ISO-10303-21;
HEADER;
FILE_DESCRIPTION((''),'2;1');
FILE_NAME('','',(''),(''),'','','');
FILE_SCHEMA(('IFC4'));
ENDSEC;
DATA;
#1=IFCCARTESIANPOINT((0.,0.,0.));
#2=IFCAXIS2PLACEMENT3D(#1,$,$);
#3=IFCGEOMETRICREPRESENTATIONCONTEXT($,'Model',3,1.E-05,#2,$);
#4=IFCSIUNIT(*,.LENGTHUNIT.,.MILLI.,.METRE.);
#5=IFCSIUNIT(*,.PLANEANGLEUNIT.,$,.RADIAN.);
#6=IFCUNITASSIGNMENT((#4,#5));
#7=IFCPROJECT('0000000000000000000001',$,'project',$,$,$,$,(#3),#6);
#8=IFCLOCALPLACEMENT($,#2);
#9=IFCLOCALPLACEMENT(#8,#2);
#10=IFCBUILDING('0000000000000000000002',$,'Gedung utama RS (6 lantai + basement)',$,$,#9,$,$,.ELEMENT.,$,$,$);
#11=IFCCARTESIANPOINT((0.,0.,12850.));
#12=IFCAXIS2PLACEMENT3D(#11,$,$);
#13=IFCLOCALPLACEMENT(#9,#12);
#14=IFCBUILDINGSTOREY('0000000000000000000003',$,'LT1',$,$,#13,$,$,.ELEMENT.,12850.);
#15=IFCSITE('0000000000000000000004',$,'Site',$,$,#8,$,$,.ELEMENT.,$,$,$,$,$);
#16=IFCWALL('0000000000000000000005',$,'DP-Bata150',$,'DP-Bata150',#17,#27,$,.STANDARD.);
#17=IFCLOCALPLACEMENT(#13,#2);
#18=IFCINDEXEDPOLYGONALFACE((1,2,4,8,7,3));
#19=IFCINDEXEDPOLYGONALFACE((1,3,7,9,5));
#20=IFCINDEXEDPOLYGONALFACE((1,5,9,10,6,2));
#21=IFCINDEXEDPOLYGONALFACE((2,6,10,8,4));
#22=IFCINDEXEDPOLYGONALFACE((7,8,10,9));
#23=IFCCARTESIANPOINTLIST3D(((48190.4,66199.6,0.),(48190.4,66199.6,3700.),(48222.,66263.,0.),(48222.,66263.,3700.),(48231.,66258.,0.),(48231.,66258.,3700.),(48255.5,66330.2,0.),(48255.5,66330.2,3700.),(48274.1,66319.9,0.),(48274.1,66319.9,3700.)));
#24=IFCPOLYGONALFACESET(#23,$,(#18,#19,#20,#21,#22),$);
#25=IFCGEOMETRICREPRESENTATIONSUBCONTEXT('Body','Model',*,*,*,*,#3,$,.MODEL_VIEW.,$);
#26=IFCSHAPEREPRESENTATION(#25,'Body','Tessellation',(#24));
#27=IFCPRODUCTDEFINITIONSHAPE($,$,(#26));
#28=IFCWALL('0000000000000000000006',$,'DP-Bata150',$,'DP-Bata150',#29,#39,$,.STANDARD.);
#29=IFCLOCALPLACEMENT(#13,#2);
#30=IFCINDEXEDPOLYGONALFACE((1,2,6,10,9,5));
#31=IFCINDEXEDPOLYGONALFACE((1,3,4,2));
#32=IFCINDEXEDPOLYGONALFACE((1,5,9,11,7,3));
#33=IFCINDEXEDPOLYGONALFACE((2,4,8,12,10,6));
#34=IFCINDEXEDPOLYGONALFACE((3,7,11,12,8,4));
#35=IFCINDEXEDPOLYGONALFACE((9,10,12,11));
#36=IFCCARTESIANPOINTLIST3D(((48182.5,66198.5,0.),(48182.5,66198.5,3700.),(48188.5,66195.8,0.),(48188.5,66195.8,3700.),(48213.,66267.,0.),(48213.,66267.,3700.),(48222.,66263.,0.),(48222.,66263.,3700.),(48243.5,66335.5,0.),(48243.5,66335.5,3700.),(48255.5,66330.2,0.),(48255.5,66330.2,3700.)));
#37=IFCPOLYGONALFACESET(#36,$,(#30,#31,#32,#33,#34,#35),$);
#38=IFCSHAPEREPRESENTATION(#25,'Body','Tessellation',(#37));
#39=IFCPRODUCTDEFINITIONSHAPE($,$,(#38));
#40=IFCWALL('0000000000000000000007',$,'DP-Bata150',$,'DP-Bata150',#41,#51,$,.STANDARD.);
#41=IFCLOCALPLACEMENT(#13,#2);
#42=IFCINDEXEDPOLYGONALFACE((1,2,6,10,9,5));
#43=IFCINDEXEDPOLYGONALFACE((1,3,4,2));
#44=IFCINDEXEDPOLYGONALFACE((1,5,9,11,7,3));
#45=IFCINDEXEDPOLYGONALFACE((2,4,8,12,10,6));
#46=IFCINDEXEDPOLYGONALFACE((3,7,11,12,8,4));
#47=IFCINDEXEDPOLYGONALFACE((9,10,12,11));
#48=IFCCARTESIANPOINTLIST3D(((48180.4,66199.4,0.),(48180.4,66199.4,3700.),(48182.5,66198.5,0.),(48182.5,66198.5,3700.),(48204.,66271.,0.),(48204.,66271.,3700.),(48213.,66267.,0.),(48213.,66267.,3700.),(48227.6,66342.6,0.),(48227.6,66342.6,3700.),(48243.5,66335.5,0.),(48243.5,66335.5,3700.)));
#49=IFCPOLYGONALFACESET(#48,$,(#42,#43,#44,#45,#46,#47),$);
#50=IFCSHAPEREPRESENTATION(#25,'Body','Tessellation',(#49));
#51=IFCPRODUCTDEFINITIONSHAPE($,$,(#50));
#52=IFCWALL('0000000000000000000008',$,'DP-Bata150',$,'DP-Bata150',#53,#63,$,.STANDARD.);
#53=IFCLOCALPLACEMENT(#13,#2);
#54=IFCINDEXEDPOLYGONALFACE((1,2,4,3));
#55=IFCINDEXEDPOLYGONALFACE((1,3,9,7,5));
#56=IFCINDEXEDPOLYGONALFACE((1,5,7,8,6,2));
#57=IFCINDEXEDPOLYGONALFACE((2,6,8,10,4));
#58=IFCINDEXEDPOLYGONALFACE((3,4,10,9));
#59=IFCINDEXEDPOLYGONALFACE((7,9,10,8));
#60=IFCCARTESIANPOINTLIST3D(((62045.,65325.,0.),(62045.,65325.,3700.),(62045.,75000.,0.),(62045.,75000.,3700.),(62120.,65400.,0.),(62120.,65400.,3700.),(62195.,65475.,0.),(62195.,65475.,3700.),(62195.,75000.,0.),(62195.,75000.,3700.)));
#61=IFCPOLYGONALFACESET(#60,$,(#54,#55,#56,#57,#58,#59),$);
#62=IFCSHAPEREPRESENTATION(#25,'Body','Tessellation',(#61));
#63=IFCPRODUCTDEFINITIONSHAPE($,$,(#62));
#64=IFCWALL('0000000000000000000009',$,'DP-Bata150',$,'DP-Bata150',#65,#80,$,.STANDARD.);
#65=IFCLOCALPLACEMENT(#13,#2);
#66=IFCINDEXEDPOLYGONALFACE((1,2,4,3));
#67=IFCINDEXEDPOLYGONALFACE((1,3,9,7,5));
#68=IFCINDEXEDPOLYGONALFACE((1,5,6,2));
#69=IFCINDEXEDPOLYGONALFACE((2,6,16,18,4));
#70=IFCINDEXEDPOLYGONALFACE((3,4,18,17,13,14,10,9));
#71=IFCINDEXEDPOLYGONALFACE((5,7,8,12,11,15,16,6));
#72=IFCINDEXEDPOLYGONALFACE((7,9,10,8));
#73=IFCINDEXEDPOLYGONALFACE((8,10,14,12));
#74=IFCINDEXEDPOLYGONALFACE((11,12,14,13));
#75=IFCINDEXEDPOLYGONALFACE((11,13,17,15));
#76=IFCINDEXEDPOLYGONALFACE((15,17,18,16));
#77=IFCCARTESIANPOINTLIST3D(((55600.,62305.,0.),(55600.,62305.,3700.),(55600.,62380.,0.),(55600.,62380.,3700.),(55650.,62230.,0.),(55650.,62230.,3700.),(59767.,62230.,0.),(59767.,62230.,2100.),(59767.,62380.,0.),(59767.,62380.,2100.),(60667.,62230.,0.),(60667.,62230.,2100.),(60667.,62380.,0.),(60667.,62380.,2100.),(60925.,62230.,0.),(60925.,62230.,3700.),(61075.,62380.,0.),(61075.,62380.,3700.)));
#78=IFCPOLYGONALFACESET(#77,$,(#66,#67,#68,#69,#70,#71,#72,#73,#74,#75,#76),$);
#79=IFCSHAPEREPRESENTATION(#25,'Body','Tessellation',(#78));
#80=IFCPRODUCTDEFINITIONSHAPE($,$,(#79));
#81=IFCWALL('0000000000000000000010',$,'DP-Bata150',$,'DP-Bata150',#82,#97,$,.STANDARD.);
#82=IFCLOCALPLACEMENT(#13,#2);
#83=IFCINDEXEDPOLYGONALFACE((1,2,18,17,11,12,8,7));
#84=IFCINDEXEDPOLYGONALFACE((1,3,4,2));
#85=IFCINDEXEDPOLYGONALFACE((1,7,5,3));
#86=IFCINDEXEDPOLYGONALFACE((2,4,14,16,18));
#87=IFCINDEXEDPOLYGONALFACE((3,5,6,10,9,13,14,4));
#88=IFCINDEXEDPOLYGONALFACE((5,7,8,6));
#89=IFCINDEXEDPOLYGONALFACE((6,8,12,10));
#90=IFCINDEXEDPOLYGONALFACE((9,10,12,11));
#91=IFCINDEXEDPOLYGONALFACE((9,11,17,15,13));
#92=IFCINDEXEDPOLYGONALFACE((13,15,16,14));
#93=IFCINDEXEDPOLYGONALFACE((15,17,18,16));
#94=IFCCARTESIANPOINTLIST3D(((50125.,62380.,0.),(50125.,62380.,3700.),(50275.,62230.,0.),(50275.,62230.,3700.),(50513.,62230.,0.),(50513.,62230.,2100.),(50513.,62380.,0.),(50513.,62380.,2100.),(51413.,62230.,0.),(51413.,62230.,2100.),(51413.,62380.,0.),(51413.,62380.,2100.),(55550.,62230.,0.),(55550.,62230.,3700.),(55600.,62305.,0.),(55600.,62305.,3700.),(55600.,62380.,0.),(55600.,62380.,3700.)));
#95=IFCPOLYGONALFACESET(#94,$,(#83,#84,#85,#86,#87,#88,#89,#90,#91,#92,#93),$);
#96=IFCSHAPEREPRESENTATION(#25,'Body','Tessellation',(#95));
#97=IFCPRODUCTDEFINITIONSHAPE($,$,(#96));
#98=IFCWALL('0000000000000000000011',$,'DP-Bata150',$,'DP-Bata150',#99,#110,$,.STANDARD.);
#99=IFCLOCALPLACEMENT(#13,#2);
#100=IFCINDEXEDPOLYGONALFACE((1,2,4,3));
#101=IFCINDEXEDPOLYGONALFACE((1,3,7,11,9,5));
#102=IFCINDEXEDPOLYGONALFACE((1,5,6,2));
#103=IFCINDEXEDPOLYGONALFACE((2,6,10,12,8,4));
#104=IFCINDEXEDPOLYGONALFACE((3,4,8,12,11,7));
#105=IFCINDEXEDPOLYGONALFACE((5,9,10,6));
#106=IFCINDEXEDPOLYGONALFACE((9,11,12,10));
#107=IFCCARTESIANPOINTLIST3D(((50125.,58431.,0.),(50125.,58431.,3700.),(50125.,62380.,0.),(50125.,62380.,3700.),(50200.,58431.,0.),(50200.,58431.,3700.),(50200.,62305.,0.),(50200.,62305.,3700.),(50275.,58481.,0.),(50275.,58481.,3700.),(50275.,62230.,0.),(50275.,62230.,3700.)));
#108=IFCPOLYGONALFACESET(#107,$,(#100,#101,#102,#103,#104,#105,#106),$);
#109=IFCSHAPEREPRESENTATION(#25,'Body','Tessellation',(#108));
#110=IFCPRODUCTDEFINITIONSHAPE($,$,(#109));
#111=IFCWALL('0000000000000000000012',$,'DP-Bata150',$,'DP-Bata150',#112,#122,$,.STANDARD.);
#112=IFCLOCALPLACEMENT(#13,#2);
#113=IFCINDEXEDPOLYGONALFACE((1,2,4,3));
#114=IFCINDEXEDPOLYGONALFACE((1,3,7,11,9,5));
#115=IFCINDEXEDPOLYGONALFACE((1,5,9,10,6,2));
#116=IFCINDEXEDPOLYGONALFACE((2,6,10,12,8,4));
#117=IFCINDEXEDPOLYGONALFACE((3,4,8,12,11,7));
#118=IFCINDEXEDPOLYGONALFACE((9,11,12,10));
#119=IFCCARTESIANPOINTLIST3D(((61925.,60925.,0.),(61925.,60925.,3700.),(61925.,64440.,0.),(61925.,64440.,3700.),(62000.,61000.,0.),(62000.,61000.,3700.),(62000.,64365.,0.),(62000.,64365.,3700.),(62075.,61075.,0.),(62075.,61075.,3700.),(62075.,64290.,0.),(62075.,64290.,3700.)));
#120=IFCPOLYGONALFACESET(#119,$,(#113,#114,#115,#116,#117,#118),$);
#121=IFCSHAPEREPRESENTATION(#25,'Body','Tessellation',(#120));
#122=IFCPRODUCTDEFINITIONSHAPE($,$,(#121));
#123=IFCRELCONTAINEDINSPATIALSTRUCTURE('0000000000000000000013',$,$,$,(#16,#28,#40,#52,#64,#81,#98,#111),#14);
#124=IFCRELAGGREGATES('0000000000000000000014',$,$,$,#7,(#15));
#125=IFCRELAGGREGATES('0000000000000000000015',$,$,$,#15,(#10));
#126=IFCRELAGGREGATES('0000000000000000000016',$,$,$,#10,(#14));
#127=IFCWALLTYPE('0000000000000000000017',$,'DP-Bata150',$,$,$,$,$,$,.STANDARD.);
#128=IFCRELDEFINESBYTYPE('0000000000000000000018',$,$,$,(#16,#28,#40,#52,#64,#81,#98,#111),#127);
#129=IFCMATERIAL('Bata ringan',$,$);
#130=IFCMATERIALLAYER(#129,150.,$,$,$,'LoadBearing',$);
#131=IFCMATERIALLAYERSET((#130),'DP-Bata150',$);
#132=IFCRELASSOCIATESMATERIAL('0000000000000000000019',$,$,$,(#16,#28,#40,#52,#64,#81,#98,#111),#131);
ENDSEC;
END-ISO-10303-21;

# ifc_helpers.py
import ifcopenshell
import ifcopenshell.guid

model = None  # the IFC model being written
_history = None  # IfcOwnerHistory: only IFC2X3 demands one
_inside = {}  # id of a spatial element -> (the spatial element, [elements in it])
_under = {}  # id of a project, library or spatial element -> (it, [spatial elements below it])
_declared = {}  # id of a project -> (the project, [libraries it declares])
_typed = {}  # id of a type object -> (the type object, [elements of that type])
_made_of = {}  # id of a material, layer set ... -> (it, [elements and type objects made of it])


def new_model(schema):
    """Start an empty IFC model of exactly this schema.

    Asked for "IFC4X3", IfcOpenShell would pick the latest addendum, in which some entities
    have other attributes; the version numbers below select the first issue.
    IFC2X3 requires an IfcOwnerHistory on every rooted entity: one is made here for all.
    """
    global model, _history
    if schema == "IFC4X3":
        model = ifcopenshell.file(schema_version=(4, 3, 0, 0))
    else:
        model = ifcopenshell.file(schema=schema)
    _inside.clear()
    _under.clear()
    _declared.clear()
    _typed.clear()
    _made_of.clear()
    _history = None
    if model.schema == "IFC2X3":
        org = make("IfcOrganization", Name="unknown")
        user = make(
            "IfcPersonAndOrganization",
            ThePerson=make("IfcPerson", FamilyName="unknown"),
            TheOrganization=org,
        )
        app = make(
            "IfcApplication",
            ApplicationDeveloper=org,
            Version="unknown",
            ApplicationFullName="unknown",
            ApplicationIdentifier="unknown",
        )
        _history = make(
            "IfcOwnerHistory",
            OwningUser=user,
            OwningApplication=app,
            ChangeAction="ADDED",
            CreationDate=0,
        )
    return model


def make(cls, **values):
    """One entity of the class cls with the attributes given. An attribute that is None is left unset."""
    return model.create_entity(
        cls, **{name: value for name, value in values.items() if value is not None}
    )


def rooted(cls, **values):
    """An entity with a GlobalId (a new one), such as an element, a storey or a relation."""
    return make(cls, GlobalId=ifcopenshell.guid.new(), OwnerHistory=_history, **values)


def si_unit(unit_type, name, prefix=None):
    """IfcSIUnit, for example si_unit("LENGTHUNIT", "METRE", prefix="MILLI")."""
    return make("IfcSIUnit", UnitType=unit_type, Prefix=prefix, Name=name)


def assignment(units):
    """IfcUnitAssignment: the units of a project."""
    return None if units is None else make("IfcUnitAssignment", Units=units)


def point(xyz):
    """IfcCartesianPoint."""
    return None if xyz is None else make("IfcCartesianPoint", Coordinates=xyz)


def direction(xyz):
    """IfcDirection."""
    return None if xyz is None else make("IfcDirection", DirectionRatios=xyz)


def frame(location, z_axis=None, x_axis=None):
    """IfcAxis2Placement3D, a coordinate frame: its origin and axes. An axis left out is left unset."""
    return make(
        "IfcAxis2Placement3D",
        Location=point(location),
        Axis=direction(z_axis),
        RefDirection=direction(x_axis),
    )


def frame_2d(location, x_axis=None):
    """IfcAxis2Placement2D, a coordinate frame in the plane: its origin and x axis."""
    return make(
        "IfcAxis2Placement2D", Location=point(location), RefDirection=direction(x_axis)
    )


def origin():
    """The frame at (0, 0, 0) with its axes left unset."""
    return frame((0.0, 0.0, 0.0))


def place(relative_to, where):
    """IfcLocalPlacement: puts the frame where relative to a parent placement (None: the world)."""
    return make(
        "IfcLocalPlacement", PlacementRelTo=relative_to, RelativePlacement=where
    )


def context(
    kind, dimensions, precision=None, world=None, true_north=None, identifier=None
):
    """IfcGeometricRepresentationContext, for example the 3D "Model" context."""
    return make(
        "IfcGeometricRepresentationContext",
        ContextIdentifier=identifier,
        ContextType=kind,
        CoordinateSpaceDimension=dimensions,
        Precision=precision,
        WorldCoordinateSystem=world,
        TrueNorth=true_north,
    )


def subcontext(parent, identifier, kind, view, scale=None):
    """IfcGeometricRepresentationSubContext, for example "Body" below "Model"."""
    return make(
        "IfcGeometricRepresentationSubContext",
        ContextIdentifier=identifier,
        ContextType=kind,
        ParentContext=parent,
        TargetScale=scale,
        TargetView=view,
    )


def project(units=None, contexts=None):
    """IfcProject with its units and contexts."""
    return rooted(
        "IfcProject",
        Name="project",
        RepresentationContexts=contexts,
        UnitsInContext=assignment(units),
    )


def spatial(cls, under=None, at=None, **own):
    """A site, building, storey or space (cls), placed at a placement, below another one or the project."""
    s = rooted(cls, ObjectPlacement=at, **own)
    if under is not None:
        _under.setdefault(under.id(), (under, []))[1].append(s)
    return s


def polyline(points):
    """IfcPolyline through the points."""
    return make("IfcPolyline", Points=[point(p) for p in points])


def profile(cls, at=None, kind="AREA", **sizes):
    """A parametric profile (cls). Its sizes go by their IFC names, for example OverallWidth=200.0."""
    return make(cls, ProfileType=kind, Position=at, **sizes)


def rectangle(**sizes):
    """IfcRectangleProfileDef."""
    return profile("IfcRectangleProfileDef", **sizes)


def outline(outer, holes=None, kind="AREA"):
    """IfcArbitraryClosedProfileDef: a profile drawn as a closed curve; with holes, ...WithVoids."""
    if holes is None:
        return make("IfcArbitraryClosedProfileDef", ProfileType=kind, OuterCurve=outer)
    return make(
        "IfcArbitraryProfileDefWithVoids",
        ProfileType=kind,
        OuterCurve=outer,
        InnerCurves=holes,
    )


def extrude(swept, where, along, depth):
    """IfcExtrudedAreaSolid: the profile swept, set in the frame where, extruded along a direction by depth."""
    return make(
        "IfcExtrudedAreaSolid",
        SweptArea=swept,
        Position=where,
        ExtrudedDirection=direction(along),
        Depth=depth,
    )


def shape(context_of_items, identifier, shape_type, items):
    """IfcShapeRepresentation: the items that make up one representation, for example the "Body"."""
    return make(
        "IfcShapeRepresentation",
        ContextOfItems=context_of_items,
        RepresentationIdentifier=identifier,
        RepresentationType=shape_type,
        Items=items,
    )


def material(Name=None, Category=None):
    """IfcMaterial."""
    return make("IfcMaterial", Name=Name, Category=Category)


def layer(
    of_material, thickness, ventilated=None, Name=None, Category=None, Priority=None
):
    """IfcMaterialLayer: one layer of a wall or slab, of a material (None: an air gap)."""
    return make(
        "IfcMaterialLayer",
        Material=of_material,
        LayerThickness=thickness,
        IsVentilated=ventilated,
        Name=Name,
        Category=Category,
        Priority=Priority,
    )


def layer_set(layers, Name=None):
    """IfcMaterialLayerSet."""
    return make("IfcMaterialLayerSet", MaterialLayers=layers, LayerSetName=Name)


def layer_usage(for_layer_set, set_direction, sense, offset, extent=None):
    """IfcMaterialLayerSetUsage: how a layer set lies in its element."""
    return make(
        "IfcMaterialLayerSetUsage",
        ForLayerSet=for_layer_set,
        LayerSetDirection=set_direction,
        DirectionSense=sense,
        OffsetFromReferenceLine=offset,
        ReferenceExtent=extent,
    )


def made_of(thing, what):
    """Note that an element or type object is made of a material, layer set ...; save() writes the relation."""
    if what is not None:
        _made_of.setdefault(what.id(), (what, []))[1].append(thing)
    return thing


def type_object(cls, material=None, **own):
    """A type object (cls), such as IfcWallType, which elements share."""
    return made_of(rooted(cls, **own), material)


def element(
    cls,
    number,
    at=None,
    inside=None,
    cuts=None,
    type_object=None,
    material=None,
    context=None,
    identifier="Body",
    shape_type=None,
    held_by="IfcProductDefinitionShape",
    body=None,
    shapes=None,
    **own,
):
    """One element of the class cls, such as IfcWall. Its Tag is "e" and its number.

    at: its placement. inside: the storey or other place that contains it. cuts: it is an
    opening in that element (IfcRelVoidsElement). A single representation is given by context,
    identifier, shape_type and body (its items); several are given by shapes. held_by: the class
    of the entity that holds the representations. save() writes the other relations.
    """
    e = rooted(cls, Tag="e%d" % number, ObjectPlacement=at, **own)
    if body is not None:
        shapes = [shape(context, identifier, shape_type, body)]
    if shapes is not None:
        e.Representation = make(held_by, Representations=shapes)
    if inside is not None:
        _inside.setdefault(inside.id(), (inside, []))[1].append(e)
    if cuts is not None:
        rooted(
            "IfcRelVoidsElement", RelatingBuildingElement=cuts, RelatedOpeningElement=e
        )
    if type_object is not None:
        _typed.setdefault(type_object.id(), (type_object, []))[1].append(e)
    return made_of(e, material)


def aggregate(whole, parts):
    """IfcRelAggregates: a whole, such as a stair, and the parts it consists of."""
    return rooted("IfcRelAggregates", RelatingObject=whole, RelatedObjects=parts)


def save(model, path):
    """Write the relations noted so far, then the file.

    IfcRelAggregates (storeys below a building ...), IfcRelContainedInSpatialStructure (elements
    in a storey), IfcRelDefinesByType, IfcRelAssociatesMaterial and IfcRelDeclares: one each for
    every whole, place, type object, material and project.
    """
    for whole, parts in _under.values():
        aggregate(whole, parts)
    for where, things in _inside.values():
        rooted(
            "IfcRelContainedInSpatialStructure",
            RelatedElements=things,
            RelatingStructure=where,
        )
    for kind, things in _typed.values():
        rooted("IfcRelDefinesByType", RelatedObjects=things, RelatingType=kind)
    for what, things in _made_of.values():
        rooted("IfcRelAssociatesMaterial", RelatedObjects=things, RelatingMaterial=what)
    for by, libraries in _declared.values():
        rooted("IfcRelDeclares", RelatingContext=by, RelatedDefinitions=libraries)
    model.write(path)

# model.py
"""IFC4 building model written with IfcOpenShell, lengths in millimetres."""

from ifc_helpers import new_model, si_unit, frame, frame_2d, origin, place, context, subcontext, project, spatial, polyline, rectangle, outline, extrude, material, layer, layer_set, layer_usage, type_object, element, save


model = new_model("IFC4")

# Units and contexts
model_context = context("Model", 3, precision=1e-05, world=origin())
body_context = subcontext(model_context, "Body", "Model", "MODEL_VIEW")
ifc_project = project(units=[si_unit("LENGTHUNIT", "METRE", prefix="MILLI"), si_unit("PLANEANGLEUNIT", "RADIAN")], contexts=[model_context])

# Site, building, storey
site_placement = place(None, origin())
site = spatial("IfcSite", under=ifc_project, at=site_placement, Name="Site", CompositionType="ELEMENT")
building_placement = place(site_placement, origin())
building = spatial("IfcBuilding", under=site, at=building_placement, Name="Gedung utama RS (6 lantai + basement)", CompositionType="ELEMENT")
storey_placement = place(building_placement, frame((0.0, 0.0, 12850.0)))
storey = spatial("IfcBuildingStorey", under=building, at=storey_placement, Name="LT1", CompositionType="ELEMENT", Elevation=12850.0)

# Shared definitions
ifc_material = material(Name="Bata ringan")
ifc_layer = layer(ifc_material, 150.0, Category="LoadBearing")
ifc_layer_set = layer_set([ifc_layer], Name="DP-Bata150")
ifc_layer_usage = layer_usage(ifc_layer_set, "AXIS2", "NEGATIVE", 75.0)
wall_type = type_object("IfcWallType", Name="DP-Bata150", PredefinedType="STANDARD")

# Walls
wall_1_placement = place(storey_placement, frame((48231.0, 66258.0, 0.0), z_axis=(0.0, 0.0, 1.0), x_axis=(-0.874157, 0.485643, 0.0)))
element("IfcWall", 1, at=wall_1_placement, inside=storey, type_object=wall_type, material=ifc_layer_usage, Name="DP-Bata150", ObjectType="DP-Bata150", PredefinedType="STANDARD", context=body_context, shape_type="SweptSolid", body=[
    extrude(outline(polyline([(-7.6, -75.0), (0.0, 0.0), (7.6, 75.0), (7.0, 75.0), (10.3, 0.0), (13.6, -75.0), (-7.6, -75.0)])), origin(), (0.0, 0.0, 1.0), 3700.0),
])
wall_2_placement = place(storey_placement, frame((48222.0, 66263.0, 0.0), z_axis=(0.0, 0.0, 1.0), x_axis=(-0.913812, 0.406138, 0.0)))
element("IfcWall", 2, at=wall_2_placement, inside=storey, type_object=wall_type, material=ifc_layer_usage, Name="DP-Bata150", ObjectType="DP-Bata150", PredefinedType="STANDARD", context=body_context, shape_type="SweptSolid", body=[
    extrude(outline(polyline([(-3.3, -75.0), (0.0, 0.0), (3.3, 75.0), (9.8, 75.0), (9.8, 0.0), (9.8, -75.0), (-3.3, -75.0)])), origin(), (0.0, 0.0, 1.0), 3700.0),
])
wall_3_placement = place(storey_placement, frame((48213.0, 66267.0, 0.0), z_axis=(0.0, 0.0, 1.0), x_axis=(-0.913812, 0.406138, 0.0)))
element("IfcWall", 3, at=wall_3_placement, inside=storey, type_object=wall_type, material=ifc_layer_usage, Name="DP-Bata150", ObjectType="DP-Bata150", PredefinedType="STANDARD", context=body_context, shape_type="SweptSolid", body=[
    extrude(outline(polyline([(0.0, -75.0), (0.0, 0.0), (0.0, 75.0), (2.3, 75.0), (9.8, 0.0), (17.4, -75.0), (0.0, -75.0)])), origin(), (0.0, 0.0, 1.0), 3700.0),
])
wall_4_placement = place(storey_placement, frame((62120.0, 65400.0, 0.0), z_axis=(0.0, 0.0, 1.0), x_axis=(0.0, 1.0, 0.0)))
element("IfcWall", 4, at=wall_4_placement, inside=storey, type_object=wall_type, material=ifc_layer_usage, Name="DP-Bata150", ObjectType="DP-Bata150", PredefinedType="STANDARD", context=body_context, shape_type="SweptSolid", body=[
    extrude(outline(polyline([(75.0, -75.0), (0.0, 0.0), (-75.0, 75.0), (9600.0, 75.0), (9600.0, -75.0), (75.0, -75.0)])), origin(), (0.0, 0.0, 1.0), 3700.0),
])

# Walls, openings
wall_5_placement = place(storey_placement, frame((61000.0, 62305.0, 0.0), z_axis=(0.0, 0.0, 1.0), x_axis=(-1.0, 0.0, 0.0)))
wall_5 = element("IfcWall", 5, at=wall_5_placement, inside=storey, type_object=wall_type, material=ifc_layer_usage, Name="DP-Bata150", ObjectType="DP-Bata150", PredefinedType="STANDARD", context=body_context, shape_type="SweptSolid", body=[
    extrude(outline(polyline([(-75.0, -75.0), (0.0, 0.0), (75.0, 75.0), (5350.0, 75.0), (5400.0, 0.0), (5400.0, -75.0), (-75.0, -75.0)])), origin(), (0.0, 0.0, 1.0), 3700.0),
])
opening_1_placement = place(wall_5_placement, frame((333.0, 0.0, 0.0), z_axis=(0.0, 0.0, 1.0), x_axis=(1.0, 0.0, 0.0)))
element("IfcOpeningElement", 6, at=opening_1_placement, cuts=wall_5, PredefinedType="OPENING", context=body_context, shape_type="SweptSolid", body=[
    extrude(rectangle(XDim=900.0, YDim=170.0, at=frame_2d((450.0, 0.0))), origin(), (0.0, 0.0, 1.0), 2100.0),
])
wall_6_placement = place(storey_placement, frame((55600.0, 62305.0, 0.0), z_axis=(0.0, 0.0, 1.0), x_axis=(-1.0, 0.0, 0.0)))
wall_6 = element("IfcWall", 7, at=wall_6_placement, inside=storey, type_object=wall_type, material=ifc_layer_usage, Name="DP-Bata150", ObjectType="DP-Bata150", PredefinedType="STANDARD", context=body_context, shape_type="SweptSolid", body=[
    extrude(outline(polyline([(0.0, -75.0), (0.0, 0.0), (50.0, 75.0), (5325.0, 75.0), (5400.0, 0.0), (5475.0, -75.0), (0.0, -75.0)])), origin(), (0.0, 0.0, 1.0), 3700.0),
])
opening_2_placement = place(wall_6_placement, frame((4187.0, 0.0, 0.0), z_axis=(0.0, 0.0, 1.0), x_axis=(1.0, 0.0, 0.0)))
element("IfcOpeningElement", 8, at=opening_2_placement, cuts=wall_6, PredefinedType="OPENING", context=body_context, shape_type="SweptSolid", body=[
    extrude(rectangle(XDim=900.0, YDim=170.0, at=frame_2d((450.0, 0.0))), origin(), (0.0, 0.0, 1.0), 2100.0),
])

# Walls
wall_7_placement = place(storey_placement, frame((50200.0, 62305.0, 0.0), z_axis=(0.0, 0.0, 1.0), x_axis=(0.0, -1.0, 0.0)))
element("IfcWall", 9, at=wall_7_placement, inside=storey, type_object=wall_type, material=ifc_layer_usage, Name="DP-Bata150", ObjectType="DP-Bata150", PredefinedType="STANDARD", context=body_context, shape_type="SweptSolid", body=[
    extrude(outline(polyline([(-75.0, -75.0), (0.0, 0.0), (75.0, 75.0), (3824.0, 75.0), (3874.0, 0.0), (3874.0, -75.0), (-75.0, -75.0)])), origin(), (0.0, 0.0, 1.0), 3700.0),
])
wall_8_placement = place(storey_placement, frame((62000.0, 64365.0, 0.0), z_axis=(0.0, 0.0, 1.0), x_axis=(0.0, -1.0, 0.0)))
element("IfcWall", 10, at=wall_8_placement, inside=storey, type_object=wall_type, material=ifc_layer_usage, Name="DP-Bata150", ObjectType="DP-Bata150", PredefinedType="STANDARD", context=body_context, shape_type="SweptSolid", body=[
    extrude(outline(polyline([(-75.0, -75.0), (0.0, 0.0), (75.0, 75.0), (3290.0, 75.0), (3365.0, 0.0), (3440.0, -75.0), (-75.0, -75.0)])), origin(), (0.0, 0.0, 1.0), 3700.0),
])

save(model, "model.ifc")
